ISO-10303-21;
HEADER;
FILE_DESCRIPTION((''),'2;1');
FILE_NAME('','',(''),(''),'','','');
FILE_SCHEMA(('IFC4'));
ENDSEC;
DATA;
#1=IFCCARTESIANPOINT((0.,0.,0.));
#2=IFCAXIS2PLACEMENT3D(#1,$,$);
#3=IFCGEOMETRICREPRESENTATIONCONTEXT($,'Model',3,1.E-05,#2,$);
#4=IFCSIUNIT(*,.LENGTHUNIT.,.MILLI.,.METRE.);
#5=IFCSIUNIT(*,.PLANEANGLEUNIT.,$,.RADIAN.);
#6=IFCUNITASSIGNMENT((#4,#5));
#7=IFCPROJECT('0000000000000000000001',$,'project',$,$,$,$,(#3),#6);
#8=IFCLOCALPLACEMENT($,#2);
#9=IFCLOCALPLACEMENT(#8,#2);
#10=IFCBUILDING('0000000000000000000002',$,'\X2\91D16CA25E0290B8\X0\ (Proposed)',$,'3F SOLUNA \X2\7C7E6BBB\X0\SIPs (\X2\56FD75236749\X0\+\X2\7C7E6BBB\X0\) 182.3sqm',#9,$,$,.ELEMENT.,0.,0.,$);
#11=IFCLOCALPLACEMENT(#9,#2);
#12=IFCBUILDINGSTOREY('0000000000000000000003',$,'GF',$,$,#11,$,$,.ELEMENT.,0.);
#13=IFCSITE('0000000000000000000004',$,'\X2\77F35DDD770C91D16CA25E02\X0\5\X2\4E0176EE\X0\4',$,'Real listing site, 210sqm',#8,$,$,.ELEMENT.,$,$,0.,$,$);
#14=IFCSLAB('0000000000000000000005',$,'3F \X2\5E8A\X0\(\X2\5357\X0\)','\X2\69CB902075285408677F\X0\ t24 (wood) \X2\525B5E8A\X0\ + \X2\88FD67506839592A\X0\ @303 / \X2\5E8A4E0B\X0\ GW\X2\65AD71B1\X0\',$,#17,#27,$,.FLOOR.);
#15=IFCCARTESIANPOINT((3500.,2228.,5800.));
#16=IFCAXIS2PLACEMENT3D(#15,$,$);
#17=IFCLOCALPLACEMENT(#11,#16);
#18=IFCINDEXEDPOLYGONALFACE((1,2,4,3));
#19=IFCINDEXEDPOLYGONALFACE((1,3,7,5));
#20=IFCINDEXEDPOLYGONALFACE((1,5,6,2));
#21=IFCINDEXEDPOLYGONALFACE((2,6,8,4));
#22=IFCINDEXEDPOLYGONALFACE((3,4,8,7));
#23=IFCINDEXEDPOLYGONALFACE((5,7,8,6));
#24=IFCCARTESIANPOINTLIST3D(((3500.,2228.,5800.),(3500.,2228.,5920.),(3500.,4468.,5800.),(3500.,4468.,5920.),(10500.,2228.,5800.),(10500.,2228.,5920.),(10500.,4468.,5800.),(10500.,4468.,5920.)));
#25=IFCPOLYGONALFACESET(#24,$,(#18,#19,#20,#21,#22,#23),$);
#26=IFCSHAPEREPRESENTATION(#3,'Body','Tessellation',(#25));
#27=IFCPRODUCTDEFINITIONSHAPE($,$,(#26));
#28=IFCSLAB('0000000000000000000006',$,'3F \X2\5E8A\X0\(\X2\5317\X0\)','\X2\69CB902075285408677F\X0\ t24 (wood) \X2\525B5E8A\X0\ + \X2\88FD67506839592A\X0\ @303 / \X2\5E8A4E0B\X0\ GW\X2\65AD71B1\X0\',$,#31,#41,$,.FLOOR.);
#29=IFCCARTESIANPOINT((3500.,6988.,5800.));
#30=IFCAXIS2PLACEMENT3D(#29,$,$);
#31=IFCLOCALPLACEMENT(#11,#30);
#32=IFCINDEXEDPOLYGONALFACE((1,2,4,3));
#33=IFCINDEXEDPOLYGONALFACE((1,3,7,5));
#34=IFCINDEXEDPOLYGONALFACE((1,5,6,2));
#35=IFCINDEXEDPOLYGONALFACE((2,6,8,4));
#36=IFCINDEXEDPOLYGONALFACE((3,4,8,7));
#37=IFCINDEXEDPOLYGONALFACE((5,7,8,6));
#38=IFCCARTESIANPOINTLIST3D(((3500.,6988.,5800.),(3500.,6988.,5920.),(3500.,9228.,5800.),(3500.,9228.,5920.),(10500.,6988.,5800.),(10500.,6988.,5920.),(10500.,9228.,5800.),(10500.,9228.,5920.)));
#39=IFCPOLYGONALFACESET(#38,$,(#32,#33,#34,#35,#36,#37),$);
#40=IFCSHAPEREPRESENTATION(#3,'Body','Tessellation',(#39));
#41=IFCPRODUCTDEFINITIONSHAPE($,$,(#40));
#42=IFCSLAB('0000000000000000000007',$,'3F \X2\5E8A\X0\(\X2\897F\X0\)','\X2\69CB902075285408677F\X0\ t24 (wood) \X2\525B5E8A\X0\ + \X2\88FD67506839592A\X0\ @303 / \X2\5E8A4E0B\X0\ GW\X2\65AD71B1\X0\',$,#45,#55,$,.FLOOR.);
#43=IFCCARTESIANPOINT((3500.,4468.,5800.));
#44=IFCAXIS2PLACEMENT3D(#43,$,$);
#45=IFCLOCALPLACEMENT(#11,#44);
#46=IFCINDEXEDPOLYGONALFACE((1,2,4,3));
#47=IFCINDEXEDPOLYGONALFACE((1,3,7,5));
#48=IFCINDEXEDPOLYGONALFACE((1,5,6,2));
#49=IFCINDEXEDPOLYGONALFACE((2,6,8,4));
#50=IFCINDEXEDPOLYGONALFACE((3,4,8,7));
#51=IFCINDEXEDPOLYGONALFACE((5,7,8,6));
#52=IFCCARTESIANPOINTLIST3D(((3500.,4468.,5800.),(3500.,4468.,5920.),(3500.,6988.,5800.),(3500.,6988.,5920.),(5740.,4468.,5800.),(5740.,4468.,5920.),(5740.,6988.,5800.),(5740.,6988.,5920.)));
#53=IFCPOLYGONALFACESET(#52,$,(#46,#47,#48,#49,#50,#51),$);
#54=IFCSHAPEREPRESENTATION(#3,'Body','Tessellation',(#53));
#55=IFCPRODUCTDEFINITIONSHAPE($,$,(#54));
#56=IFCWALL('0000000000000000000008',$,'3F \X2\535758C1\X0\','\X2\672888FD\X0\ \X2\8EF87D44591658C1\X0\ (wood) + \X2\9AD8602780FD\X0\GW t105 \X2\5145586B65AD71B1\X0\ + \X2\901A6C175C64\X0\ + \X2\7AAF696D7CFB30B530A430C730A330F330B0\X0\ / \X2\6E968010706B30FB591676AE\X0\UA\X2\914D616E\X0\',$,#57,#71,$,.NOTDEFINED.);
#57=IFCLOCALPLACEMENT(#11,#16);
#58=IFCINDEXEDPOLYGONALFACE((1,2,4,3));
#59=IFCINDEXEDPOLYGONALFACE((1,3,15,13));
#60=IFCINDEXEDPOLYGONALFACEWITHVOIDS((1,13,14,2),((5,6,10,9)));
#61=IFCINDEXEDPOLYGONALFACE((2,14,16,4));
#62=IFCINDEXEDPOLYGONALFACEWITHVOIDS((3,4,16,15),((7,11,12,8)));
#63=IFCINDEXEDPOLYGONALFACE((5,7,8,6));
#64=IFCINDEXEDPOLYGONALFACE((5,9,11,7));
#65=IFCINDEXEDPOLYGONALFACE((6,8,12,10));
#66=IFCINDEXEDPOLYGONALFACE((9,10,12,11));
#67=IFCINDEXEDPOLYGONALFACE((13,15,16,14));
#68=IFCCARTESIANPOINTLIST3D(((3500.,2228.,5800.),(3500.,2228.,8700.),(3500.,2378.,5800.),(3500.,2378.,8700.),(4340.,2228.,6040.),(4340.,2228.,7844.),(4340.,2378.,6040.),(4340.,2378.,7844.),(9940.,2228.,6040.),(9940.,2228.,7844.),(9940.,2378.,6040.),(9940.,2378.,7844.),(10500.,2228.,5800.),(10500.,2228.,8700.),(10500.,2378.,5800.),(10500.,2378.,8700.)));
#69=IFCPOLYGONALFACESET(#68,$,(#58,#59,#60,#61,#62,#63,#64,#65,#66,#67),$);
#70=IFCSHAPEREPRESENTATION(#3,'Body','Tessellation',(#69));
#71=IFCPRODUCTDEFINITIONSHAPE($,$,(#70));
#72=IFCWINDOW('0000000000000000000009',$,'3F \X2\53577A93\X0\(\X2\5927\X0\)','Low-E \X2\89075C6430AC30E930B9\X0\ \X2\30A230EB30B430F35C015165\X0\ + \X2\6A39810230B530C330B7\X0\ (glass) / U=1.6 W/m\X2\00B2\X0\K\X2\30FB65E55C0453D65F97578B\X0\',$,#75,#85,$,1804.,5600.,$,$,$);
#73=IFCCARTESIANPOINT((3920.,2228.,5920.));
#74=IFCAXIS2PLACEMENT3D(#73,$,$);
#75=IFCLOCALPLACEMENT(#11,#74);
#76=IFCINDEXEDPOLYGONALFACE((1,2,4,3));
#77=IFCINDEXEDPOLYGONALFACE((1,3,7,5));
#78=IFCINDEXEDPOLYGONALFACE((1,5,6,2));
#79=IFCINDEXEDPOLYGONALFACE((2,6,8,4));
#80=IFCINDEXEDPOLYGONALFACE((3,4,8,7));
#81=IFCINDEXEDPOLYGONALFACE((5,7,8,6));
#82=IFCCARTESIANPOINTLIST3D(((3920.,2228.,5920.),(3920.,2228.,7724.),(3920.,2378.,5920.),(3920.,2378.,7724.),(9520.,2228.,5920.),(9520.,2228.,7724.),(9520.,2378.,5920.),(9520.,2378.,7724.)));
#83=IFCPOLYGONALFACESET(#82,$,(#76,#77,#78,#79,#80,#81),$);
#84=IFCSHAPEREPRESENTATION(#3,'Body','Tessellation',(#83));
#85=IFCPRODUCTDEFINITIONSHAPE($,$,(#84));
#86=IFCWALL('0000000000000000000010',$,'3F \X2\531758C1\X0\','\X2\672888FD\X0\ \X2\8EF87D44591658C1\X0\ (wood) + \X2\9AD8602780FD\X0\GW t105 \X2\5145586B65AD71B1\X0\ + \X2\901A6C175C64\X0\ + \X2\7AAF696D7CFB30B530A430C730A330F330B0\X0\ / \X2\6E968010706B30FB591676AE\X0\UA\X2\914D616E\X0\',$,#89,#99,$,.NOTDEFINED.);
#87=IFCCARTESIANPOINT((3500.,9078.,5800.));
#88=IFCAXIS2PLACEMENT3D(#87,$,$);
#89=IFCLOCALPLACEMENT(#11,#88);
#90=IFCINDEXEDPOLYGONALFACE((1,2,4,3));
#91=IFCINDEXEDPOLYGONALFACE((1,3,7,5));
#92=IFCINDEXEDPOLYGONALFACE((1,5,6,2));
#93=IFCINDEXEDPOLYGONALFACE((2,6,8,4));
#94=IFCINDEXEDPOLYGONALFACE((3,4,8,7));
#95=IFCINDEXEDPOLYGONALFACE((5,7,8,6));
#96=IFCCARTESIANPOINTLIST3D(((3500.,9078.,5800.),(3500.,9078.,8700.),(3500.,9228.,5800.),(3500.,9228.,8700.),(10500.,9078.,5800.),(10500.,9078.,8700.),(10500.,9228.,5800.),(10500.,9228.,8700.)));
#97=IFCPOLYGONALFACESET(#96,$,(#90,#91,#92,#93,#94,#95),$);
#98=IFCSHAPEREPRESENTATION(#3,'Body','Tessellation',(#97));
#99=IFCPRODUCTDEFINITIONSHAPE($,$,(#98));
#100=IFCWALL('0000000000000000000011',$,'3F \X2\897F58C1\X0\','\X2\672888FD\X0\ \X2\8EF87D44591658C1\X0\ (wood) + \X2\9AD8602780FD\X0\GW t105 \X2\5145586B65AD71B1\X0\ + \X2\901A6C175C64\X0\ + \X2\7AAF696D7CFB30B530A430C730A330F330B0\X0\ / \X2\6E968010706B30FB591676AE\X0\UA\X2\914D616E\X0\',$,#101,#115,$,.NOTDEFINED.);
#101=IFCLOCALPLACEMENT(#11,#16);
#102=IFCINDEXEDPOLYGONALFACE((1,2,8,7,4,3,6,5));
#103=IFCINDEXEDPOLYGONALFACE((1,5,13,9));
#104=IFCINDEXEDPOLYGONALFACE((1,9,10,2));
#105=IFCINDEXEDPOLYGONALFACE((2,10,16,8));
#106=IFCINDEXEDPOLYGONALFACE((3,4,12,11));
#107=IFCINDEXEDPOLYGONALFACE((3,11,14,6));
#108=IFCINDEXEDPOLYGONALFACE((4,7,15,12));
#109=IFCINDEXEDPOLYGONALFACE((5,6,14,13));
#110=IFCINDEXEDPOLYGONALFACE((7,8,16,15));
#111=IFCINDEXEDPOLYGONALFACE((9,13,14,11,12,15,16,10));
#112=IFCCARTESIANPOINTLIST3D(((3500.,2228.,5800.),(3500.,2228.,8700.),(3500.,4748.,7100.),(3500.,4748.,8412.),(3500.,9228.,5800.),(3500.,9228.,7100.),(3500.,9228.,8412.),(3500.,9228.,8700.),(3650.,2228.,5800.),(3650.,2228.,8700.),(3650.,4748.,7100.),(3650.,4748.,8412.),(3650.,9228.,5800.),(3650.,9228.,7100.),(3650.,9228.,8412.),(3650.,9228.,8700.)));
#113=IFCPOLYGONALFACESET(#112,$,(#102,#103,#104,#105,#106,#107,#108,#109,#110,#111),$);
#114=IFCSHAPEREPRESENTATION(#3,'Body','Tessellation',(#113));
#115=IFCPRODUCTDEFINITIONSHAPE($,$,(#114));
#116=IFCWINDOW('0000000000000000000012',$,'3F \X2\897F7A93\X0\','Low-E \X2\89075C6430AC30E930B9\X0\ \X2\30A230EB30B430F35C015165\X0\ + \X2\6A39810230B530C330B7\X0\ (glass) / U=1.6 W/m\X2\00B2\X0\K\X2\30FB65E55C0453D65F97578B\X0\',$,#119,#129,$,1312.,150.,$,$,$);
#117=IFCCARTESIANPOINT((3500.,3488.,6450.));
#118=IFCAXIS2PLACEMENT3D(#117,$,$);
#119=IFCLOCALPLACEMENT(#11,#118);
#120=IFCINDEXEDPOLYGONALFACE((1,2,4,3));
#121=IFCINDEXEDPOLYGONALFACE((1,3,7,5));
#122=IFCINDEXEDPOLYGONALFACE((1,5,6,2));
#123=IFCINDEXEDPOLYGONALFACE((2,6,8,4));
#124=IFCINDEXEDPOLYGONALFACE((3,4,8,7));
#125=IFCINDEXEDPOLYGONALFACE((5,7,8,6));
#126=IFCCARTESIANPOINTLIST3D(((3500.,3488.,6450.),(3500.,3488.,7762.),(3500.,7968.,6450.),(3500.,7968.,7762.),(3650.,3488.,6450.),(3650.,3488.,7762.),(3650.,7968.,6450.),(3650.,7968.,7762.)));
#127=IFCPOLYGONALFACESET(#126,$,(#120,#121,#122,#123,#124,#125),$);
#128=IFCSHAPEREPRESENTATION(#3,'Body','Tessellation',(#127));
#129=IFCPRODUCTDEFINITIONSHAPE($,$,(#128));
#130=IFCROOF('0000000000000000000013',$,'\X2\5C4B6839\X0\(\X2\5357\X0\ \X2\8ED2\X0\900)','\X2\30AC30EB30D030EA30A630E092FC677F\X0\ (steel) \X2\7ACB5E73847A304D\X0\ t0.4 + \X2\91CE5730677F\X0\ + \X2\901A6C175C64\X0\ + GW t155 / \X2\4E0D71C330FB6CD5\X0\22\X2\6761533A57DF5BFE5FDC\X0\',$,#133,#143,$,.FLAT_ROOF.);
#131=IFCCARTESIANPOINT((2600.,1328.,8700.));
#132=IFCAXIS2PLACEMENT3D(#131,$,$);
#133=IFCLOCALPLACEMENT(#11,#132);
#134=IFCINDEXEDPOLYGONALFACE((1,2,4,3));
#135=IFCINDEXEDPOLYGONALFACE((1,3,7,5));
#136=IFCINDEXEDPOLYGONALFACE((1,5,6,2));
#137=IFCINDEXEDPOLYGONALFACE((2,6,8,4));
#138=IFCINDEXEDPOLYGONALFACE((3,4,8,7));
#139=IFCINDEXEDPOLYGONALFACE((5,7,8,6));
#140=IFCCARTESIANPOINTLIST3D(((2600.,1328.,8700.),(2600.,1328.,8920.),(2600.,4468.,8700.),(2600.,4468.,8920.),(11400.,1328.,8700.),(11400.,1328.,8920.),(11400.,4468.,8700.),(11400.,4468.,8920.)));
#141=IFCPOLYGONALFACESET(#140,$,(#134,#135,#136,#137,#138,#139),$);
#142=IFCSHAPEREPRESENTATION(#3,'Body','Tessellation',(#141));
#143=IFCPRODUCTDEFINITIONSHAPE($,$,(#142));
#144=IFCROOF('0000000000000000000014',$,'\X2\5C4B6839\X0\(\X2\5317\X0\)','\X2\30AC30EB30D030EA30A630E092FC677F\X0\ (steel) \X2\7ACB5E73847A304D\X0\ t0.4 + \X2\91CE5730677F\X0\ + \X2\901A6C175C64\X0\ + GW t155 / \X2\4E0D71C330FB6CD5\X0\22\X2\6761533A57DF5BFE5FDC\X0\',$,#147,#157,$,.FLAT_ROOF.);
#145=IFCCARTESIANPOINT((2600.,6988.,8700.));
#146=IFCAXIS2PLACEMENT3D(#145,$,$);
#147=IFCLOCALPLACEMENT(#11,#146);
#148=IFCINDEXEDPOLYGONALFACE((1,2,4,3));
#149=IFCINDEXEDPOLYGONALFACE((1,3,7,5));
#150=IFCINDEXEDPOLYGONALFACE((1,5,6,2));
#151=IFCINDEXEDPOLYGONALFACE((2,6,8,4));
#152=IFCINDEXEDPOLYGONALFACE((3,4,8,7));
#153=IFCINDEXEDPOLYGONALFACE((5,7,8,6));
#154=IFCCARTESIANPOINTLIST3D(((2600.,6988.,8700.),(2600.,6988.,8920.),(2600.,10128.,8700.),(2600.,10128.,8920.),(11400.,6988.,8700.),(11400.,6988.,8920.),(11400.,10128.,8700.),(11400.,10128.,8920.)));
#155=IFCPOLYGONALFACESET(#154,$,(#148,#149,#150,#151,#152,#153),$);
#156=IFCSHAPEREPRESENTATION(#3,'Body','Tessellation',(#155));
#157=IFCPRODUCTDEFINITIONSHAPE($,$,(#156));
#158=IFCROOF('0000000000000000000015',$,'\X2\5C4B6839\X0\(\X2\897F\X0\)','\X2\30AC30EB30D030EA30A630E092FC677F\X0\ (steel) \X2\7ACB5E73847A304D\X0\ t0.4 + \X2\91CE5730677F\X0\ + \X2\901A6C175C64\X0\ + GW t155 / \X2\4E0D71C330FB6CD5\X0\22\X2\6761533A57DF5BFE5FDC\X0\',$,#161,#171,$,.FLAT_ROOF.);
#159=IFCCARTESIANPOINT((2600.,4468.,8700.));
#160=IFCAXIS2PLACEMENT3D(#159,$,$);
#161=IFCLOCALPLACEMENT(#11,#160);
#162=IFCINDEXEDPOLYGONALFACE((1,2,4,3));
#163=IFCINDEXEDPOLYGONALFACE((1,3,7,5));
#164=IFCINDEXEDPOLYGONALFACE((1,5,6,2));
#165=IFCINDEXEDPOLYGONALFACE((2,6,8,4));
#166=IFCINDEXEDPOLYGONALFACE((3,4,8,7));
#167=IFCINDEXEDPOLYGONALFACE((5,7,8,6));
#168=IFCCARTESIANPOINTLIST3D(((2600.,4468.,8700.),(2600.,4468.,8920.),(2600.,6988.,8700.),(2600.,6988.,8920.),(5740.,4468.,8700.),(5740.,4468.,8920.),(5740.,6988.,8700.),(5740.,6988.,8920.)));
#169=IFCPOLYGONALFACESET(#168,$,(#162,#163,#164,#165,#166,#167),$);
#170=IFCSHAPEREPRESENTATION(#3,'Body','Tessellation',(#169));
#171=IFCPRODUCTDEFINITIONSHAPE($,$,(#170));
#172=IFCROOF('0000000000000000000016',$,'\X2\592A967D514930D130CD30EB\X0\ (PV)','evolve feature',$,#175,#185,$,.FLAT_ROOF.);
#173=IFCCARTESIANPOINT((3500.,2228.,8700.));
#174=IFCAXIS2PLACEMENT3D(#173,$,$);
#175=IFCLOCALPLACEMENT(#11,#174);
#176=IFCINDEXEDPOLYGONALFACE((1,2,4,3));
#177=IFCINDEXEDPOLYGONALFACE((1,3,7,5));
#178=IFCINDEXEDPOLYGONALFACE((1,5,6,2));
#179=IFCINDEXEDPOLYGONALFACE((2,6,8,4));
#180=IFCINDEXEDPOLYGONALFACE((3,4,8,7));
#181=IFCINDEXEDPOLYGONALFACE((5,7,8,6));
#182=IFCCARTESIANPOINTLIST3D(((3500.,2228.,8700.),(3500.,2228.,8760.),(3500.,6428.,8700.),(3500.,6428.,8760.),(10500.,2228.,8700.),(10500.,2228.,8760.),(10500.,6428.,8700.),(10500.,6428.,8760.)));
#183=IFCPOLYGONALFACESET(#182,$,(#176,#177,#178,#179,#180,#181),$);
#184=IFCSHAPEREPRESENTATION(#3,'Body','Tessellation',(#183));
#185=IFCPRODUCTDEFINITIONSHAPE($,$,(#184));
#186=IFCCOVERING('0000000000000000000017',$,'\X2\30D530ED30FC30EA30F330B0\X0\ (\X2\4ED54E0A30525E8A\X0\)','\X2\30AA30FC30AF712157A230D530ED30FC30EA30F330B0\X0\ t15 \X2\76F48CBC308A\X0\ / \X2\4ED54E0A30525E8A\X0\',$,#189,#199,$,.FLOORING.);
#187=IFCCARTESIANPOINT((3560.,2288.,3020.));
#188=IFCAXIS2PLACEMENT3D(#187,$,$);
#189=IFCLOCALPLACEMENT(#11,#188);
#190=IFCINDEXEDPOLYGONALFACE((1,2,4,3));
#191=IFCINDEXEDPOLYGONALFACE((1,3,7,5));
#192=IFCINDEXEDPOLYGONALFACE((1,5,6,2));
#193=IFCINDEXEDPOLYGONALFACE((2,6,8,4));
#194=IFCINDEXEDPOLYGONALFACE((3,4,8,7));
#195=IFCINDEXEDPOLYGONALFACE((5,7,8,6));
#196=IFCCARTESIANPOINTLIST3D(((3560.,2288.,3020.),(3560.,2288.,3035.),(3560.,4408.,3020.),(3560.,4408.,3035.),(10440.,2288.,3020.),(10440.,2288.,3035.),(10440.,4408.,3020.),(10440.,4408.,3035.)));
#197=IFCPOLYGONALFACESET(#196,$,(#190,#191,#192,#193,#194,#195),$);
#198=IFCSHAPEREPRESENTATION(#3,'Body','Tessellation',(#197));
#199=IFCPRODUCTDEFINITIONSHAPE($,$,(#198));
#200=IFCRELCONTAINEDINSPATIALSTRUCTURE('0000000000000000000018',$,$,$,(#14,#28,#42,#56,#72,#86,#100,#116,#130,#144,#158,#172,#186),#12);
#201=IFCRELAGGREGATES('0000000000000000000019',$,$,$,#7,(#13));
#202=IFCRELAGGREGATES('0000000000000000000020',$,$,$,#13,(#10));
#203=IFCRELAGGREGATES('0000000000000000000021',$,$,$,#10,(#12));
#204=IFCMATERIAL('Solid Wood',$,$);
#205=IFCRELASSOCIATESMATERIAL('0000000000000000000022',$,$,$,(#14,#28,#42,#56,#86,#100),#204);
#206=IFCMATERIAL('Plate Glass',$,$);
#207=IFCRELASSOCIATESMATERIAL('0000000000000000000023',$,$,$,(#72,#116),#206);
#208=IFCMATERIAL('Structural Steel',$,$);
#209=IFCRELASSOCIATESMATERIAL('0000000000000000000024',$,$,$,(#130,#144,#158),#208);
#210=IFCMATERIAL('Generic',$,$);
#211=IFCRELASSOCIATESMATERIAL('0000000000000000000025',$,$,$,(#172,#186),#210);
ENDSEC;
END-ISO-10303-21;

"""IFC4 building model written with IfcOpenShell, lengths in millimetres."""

from ifc_helpers import new_model, si_unit, frame, frame_2d, origin, place, context, project, spatial, rectangle, extrude, material, element, fill, save


model = new_model("IFC4")

# Units and contexts
model_context = context("Model", 3, precision=1e-05, world=origin())
ifc_project = project(units=[si_unit("LENGTHUNIT", "METRE", prefix="MILLI"), si_unit("PLANEANGLEUNIT", "RADIAN")], contexts=[model_context])

# Site, building, storey
site_placement = place(None, origin())
site = spatial("IfcSite", under=ifc_project, at=site_placement, Name="石川県金沢市5丁目4", ObjectType="Real listing site, 210sqm", CompositionType="ELEMENT", RefElevation=0.0)
building_placement = place(site_placement, origin())
building = spatial("IfcBuilding", under=site, at=building_placement, Name="金沢市邸 (Proposed)", ObjectType="3F SOLUNA 籾殻SIPs (国産杉+籾殻) 182.3sqm", CompositionType="ELEMENT", ElevationOfRefHeight=0.0, ElevationOfTerrain=0.0)
storey_placement = place(building_placement, origin())
storey = spatial("IfcBuildingStorey", under=building, at=storey_placement, Name="GF", CompositionType="ELEMENT", Elevation=0.0)

# Slabs
ifc_material_1 = material(Name="Solid Wood")
slab_1_placement = place(storey_placement, frame((3500.0, 2228.0, 5800.0)))
element("IfcSlab", 1, at=slab_1_placement, inside=storey, material=ifc_material_1, Name="3F 床(南)", Description="構造用合板 t24 (wood) 剛床 + 製材根太 @303 / 床下 GW断熱", PredefinedType="FLOOR", context=model_context, shape_type="SweptSolid", body=[
    extrude(rectangle(XDim=7000.0, YDim=2240.0, at=frame_2d((3500.0, 1120.0))), frame((3500.0, 2228.0, 5800.0)), (0.0, 0.0, 1.0), 120.0),
])
slab_2_placement = place(storey_placement, frame((3500.0, 6988.0, 5800.0)))
element("IfcSlab", 2, at=slab_2_placement, inside=storey, material=ifc_material_1, Name="3F 床(北)", Description="構造用合板 t24 (wood) 剛床 + 製材根太 @303 / 床下 GW断熱", PredefinedType="FLOOR", context=model_context, shape_type="SweptSolid", body=[
    extrude(rectangle(XDim=7000.0, YDim=2240.0, at=frame_2d((3500.0, 1120.0))), frame((3500.0, 6988.0, 5800.0)), (0.0, 0.0, 1.0), 120.0),
])
slab_3_placement = place(storey_placement, frame((3500.0, 4468.0, 5800.0)))
element("IfcSlab", 3, at=slab_3_placement, inside=storey, material=ifc_material_1, Name="3F 床(西)", Description="構造用合板 t24 (wood) 剛床 + 製材根太 @303 / 床下 GW断熱", PredefinedType="FLOOR", context=model_context, shape_type="SweptSolid", body=[
    extrude(rectangle(XDim=2240.0, YDim=2520.0, at=frame_2d((1120.0, 1260.0))), frame((3500.0, 4468.0, 5800.0)), (0.0, 0.0, 1.0), 120.0),
])

# Wall, opening, window
wall_1_placement = place(storey_placement, frame((3500.0, 2228.0, 5800.0)))
wall_1 = element("IfcWall", 4, at=wall_1_placement, inside=storey, material=ifc_material_1, Name="3F 南壁", Description="木製 軸組外壁 (wood) + 高性能GW t105 充填断熱 + 通気層 + 窯業系サイディング / 準耐火・外皮UA配慮", PredefinedType="NOTDEFINED", context=model_context, shape_type="SweptSolid", body=[
    extrude(rectangle(XDim=7000.0, YDim=150.0, at=frame_2d((3500.0, 75.0))), frame((3500.0, 2228.0, 5800.0)), (0.0, 0.0, 1.0), 2900.0),
])
opening_1_placement = place(storey_placement, frame((3920.0, 2228.0, 5920.0)))
opening_1 = element("IfcOpeningElement", 5, at=opening_1_placement, cuts=wall_1, PredefinedType="NOTDEFINED", context=model_context, shape_type="SweptSolid", body=[
    extrude(rectangle(XDim=5600.0, YDim=150.0, at=frame_2d((2800.0, 75.0))), frame((3920.0, 2228.0, 5920.0)), (0.0, 0.0, 1.0), 1804.0),
])
ifc_material_2 = material(Name="Plate Glass")
window_1_placement = place(storey_placement, frame((3920.0, 2228.0, 5920.0)))
window_1 = element("IfcWindow", 6, at=window_1_placement, inside=storey, material=ifc_material_2, Name="3F 南窓(大)", Description="Low-E 複層ガラス アルゴン封入 + 樹脂サッシ (glass) / U=1.6 W/m²K・日射取得型", OverallHeight=1804.0, OverallWidth=5600.0, context=model_context, shape_type="SweptSolid", body=[
    extrude(rectangle(XDim=5600.0, YDim=150.0, at=frame_2d((2800.0, 75.0))), frame((3920.0, 2228.0, 5920.0)), (0.0, 0.0, 1.0), 1804.0),
])
fill(opening_1, window_1)

# Wall
wall_2_placement = place(storey_placement, frame((3500.0, 9078.0, 5800.0)))
element("IfcWall", 7, at=wall_2_placement, inside=storey, material=ifc_material_1, Name="3F 北壁", Description="木製 軸組外壁 (wood) + 高性能GW t105 充填断熱 + 通気層 + 窯業系サイディング / 準耐火・外皮UA配慮", PredefinedType="NOTDEFINED", context=model_context, shape_type="SweptSolid", body=[
    extrude(rectangle(XDim=7000.0, YDim=150.0, at=frame_2d((3500.0, 75.0))), frame((3500.0, 9078.0, 5800.0)), (0.0, 0.0, 1.0), 2900.0),
])

# Wall, opening, window
wall_3_placement = place(storey_placement, frame((3500.0, 2228.0, 5800.0)))
wall_3 = element("IfcWall", 8, at=wall_3_placement, inside=storey, material=ifc_material_1, Name="3F 西壁", Description="木製 軸組外壁 (wood) + 高性能GW t105 充填断熱 + 通気層 + 窯業系サイディング / 準耐火・外皮UA配慮", PredefinedType="NOTDEFINED", context=model_context, shape_type="SweptSolid", body=[
    extrude(rectangle(XDim=150.0, YDim=7000.0, at=frame_2d((75.0, 3500.0))), frame((3500.0, 2228.0, 5800.0)), (0.0, 0.0, 1.0), 2900.0),
])
opening_2_placement = place(storey_placement, frame((3500.0, 3488.0, 6450.0)))
opening_2 = element("IfcOpeningElement", 9, at=opening_2_placement, cuts=wall_3, PredefinedType="NOTDEFINED", context=model_context, shape_type="SweptSolid", body=[
    extrude(rectangle(XDim=150.0, YDim=4480.0, at=frame_2d((75.0, 2240.0))), frame((3500.0, 3488.0, 6450.0)), (0.0, 0.0, 1.0), 1312.0),
])
window_2_placement = place(storey_placement, frame((3500.0, 3488.0, 6450.0)))
window_2 = element("IfcWindow", 10, at=window_2_placement, inside=storey, material=ifc_material_2, Name="3F 西窓", Description="Low-E 複層ガラス アルゴン封入 + 樹脂サッシ (glass) / U=1.6 W/m²K・日射取得型", OverallHeight=1312.0, OverallWidth=150.0, context=model_context, shape_type="SweptSolid", body=[
    extrude(rectangle(XDim=150.0, YDim=4480.0, at=frame_2d((75.0, 2240.0))), frame((3500.0, 3488.0, 6450.0)), (0.0, 0.0, 1.0), 1312.0),
])
fill(opening_2, window_2)

# Roofs
ifc_material_3 = material(Name="Structural Steel")
roof_1_placement = place(storey_placement, frame((2600.0, 1328.0, 8700.0)))
element("IfcRoof", 11, at=roof_1_placement, inside=storey, material=ifc_material_3, Name="屋根(南 軒900)", Description="ガルバリウム鋼板 (steel) 立平葺き t0.4 + 野地板 + 通気層 + GW t155 / 不燃・法22条区域対応", PredefinedType="FLAT_ROOF", context=model_context, shape_type="SweptSolid", body=[
    extrude(rectangle(XDim=8800.0, YDim=3140.0, at=frame_2d((4400.0, 1570.0))), frame((2600.0, 1328.0, 8700.0)), (0.0, 0.0, 1.0), 220.0),
])
roof_2_placement = place(storey_placement, frame((2600.0, 6988.0, 8700.0)))
element("IfcRoof", 12, at=roof_2_placement, inside=storey, material=ifc_material_3, Name="屋根(北)", Description="ガルバリウム鋼板 (steel) 立平葺き t0.4 + 野地板 + 通気層 + GW t155 / 不燃・法22条区域対応", PredefinedType="FLAT_ROOF", context=model_context, shape_type="SweptSolid", body=[
    extrude(rectangle(XDim=8800.0, YDim=3140.0, at=frame_2d((4400.0, 1570.0))), frame((2600.0, 6988.0, 8700.0)), (0.0, 0.0, 1.0), 220.0),
])
roof_3_placement = place(storey_placement, frame((2600.0, 4468.0, 8700.0)))
element("IfcRoof", 13, at=roof_3_placement, inside=storey, material=ifc_material_3, Name="屋根(西)", Description="ガルバリウム鋼板 (steel) 立平葺き t0.4 + 野地板 + 通気層 + GW t155 / 不燃・法22条区域対応", PredefinedType="FLAT_ROOF", context=model_context, shape_type="SweptSolid", body=[
    extrude(rectangle(XDim=3140.0, YDim=2520.0, at=frame_2d((1570.0, 1260.0))), frame((2600.0, 4468.0, 8700.0)), (0.0, 0.0, 1.0), 220.0),
])
ifc_material_4 = material(Name="Generic")
roof_4_placement = place(storey_placement, frame((3500.0, 2228.0, 8700.0)))
element("IfcRoof", 14, at=roof_4_placement, inside=storey, material=ifc_material_4, Name="太陽光パネル (PV)", Description="evolve feature", PredefinedType="FLAT_ROOF", context=model_context, shape_type="SweptSolid", body=[
    extrude(rectangle(XDim=7000.0, YDim=4200.0, at=frame_2d((3500.0, 2100.0))), frame((3500.0, 2228.0, 8700.0)), (0.0, 0.0, 1.0), 60.0),
])

# Covering
covering_1_placement = place(storey_placement, frame((3560.0, 2288.0, 3020.0)))
element("IfcCovering", 15, at=covering_1_placement, inside=storey, material=ifc_material_4, Name="フローリング (仕上げ床)", Description="オーク無垢フローリング t15 直貼り / 仕上げ床", PredefinedType="FLOORING", context=model_context, shape_type="SweptSolid", body=[
    extrude(rectangle(XDim=6880.0, YDim=2120.0, at=frame_2d((3440.0, 1060.0))), frame((3560.0, 2288.0, 3020.0)), (0.0, 0.0, 1.0), 15.0),
])

save(model, "model.ifc")
